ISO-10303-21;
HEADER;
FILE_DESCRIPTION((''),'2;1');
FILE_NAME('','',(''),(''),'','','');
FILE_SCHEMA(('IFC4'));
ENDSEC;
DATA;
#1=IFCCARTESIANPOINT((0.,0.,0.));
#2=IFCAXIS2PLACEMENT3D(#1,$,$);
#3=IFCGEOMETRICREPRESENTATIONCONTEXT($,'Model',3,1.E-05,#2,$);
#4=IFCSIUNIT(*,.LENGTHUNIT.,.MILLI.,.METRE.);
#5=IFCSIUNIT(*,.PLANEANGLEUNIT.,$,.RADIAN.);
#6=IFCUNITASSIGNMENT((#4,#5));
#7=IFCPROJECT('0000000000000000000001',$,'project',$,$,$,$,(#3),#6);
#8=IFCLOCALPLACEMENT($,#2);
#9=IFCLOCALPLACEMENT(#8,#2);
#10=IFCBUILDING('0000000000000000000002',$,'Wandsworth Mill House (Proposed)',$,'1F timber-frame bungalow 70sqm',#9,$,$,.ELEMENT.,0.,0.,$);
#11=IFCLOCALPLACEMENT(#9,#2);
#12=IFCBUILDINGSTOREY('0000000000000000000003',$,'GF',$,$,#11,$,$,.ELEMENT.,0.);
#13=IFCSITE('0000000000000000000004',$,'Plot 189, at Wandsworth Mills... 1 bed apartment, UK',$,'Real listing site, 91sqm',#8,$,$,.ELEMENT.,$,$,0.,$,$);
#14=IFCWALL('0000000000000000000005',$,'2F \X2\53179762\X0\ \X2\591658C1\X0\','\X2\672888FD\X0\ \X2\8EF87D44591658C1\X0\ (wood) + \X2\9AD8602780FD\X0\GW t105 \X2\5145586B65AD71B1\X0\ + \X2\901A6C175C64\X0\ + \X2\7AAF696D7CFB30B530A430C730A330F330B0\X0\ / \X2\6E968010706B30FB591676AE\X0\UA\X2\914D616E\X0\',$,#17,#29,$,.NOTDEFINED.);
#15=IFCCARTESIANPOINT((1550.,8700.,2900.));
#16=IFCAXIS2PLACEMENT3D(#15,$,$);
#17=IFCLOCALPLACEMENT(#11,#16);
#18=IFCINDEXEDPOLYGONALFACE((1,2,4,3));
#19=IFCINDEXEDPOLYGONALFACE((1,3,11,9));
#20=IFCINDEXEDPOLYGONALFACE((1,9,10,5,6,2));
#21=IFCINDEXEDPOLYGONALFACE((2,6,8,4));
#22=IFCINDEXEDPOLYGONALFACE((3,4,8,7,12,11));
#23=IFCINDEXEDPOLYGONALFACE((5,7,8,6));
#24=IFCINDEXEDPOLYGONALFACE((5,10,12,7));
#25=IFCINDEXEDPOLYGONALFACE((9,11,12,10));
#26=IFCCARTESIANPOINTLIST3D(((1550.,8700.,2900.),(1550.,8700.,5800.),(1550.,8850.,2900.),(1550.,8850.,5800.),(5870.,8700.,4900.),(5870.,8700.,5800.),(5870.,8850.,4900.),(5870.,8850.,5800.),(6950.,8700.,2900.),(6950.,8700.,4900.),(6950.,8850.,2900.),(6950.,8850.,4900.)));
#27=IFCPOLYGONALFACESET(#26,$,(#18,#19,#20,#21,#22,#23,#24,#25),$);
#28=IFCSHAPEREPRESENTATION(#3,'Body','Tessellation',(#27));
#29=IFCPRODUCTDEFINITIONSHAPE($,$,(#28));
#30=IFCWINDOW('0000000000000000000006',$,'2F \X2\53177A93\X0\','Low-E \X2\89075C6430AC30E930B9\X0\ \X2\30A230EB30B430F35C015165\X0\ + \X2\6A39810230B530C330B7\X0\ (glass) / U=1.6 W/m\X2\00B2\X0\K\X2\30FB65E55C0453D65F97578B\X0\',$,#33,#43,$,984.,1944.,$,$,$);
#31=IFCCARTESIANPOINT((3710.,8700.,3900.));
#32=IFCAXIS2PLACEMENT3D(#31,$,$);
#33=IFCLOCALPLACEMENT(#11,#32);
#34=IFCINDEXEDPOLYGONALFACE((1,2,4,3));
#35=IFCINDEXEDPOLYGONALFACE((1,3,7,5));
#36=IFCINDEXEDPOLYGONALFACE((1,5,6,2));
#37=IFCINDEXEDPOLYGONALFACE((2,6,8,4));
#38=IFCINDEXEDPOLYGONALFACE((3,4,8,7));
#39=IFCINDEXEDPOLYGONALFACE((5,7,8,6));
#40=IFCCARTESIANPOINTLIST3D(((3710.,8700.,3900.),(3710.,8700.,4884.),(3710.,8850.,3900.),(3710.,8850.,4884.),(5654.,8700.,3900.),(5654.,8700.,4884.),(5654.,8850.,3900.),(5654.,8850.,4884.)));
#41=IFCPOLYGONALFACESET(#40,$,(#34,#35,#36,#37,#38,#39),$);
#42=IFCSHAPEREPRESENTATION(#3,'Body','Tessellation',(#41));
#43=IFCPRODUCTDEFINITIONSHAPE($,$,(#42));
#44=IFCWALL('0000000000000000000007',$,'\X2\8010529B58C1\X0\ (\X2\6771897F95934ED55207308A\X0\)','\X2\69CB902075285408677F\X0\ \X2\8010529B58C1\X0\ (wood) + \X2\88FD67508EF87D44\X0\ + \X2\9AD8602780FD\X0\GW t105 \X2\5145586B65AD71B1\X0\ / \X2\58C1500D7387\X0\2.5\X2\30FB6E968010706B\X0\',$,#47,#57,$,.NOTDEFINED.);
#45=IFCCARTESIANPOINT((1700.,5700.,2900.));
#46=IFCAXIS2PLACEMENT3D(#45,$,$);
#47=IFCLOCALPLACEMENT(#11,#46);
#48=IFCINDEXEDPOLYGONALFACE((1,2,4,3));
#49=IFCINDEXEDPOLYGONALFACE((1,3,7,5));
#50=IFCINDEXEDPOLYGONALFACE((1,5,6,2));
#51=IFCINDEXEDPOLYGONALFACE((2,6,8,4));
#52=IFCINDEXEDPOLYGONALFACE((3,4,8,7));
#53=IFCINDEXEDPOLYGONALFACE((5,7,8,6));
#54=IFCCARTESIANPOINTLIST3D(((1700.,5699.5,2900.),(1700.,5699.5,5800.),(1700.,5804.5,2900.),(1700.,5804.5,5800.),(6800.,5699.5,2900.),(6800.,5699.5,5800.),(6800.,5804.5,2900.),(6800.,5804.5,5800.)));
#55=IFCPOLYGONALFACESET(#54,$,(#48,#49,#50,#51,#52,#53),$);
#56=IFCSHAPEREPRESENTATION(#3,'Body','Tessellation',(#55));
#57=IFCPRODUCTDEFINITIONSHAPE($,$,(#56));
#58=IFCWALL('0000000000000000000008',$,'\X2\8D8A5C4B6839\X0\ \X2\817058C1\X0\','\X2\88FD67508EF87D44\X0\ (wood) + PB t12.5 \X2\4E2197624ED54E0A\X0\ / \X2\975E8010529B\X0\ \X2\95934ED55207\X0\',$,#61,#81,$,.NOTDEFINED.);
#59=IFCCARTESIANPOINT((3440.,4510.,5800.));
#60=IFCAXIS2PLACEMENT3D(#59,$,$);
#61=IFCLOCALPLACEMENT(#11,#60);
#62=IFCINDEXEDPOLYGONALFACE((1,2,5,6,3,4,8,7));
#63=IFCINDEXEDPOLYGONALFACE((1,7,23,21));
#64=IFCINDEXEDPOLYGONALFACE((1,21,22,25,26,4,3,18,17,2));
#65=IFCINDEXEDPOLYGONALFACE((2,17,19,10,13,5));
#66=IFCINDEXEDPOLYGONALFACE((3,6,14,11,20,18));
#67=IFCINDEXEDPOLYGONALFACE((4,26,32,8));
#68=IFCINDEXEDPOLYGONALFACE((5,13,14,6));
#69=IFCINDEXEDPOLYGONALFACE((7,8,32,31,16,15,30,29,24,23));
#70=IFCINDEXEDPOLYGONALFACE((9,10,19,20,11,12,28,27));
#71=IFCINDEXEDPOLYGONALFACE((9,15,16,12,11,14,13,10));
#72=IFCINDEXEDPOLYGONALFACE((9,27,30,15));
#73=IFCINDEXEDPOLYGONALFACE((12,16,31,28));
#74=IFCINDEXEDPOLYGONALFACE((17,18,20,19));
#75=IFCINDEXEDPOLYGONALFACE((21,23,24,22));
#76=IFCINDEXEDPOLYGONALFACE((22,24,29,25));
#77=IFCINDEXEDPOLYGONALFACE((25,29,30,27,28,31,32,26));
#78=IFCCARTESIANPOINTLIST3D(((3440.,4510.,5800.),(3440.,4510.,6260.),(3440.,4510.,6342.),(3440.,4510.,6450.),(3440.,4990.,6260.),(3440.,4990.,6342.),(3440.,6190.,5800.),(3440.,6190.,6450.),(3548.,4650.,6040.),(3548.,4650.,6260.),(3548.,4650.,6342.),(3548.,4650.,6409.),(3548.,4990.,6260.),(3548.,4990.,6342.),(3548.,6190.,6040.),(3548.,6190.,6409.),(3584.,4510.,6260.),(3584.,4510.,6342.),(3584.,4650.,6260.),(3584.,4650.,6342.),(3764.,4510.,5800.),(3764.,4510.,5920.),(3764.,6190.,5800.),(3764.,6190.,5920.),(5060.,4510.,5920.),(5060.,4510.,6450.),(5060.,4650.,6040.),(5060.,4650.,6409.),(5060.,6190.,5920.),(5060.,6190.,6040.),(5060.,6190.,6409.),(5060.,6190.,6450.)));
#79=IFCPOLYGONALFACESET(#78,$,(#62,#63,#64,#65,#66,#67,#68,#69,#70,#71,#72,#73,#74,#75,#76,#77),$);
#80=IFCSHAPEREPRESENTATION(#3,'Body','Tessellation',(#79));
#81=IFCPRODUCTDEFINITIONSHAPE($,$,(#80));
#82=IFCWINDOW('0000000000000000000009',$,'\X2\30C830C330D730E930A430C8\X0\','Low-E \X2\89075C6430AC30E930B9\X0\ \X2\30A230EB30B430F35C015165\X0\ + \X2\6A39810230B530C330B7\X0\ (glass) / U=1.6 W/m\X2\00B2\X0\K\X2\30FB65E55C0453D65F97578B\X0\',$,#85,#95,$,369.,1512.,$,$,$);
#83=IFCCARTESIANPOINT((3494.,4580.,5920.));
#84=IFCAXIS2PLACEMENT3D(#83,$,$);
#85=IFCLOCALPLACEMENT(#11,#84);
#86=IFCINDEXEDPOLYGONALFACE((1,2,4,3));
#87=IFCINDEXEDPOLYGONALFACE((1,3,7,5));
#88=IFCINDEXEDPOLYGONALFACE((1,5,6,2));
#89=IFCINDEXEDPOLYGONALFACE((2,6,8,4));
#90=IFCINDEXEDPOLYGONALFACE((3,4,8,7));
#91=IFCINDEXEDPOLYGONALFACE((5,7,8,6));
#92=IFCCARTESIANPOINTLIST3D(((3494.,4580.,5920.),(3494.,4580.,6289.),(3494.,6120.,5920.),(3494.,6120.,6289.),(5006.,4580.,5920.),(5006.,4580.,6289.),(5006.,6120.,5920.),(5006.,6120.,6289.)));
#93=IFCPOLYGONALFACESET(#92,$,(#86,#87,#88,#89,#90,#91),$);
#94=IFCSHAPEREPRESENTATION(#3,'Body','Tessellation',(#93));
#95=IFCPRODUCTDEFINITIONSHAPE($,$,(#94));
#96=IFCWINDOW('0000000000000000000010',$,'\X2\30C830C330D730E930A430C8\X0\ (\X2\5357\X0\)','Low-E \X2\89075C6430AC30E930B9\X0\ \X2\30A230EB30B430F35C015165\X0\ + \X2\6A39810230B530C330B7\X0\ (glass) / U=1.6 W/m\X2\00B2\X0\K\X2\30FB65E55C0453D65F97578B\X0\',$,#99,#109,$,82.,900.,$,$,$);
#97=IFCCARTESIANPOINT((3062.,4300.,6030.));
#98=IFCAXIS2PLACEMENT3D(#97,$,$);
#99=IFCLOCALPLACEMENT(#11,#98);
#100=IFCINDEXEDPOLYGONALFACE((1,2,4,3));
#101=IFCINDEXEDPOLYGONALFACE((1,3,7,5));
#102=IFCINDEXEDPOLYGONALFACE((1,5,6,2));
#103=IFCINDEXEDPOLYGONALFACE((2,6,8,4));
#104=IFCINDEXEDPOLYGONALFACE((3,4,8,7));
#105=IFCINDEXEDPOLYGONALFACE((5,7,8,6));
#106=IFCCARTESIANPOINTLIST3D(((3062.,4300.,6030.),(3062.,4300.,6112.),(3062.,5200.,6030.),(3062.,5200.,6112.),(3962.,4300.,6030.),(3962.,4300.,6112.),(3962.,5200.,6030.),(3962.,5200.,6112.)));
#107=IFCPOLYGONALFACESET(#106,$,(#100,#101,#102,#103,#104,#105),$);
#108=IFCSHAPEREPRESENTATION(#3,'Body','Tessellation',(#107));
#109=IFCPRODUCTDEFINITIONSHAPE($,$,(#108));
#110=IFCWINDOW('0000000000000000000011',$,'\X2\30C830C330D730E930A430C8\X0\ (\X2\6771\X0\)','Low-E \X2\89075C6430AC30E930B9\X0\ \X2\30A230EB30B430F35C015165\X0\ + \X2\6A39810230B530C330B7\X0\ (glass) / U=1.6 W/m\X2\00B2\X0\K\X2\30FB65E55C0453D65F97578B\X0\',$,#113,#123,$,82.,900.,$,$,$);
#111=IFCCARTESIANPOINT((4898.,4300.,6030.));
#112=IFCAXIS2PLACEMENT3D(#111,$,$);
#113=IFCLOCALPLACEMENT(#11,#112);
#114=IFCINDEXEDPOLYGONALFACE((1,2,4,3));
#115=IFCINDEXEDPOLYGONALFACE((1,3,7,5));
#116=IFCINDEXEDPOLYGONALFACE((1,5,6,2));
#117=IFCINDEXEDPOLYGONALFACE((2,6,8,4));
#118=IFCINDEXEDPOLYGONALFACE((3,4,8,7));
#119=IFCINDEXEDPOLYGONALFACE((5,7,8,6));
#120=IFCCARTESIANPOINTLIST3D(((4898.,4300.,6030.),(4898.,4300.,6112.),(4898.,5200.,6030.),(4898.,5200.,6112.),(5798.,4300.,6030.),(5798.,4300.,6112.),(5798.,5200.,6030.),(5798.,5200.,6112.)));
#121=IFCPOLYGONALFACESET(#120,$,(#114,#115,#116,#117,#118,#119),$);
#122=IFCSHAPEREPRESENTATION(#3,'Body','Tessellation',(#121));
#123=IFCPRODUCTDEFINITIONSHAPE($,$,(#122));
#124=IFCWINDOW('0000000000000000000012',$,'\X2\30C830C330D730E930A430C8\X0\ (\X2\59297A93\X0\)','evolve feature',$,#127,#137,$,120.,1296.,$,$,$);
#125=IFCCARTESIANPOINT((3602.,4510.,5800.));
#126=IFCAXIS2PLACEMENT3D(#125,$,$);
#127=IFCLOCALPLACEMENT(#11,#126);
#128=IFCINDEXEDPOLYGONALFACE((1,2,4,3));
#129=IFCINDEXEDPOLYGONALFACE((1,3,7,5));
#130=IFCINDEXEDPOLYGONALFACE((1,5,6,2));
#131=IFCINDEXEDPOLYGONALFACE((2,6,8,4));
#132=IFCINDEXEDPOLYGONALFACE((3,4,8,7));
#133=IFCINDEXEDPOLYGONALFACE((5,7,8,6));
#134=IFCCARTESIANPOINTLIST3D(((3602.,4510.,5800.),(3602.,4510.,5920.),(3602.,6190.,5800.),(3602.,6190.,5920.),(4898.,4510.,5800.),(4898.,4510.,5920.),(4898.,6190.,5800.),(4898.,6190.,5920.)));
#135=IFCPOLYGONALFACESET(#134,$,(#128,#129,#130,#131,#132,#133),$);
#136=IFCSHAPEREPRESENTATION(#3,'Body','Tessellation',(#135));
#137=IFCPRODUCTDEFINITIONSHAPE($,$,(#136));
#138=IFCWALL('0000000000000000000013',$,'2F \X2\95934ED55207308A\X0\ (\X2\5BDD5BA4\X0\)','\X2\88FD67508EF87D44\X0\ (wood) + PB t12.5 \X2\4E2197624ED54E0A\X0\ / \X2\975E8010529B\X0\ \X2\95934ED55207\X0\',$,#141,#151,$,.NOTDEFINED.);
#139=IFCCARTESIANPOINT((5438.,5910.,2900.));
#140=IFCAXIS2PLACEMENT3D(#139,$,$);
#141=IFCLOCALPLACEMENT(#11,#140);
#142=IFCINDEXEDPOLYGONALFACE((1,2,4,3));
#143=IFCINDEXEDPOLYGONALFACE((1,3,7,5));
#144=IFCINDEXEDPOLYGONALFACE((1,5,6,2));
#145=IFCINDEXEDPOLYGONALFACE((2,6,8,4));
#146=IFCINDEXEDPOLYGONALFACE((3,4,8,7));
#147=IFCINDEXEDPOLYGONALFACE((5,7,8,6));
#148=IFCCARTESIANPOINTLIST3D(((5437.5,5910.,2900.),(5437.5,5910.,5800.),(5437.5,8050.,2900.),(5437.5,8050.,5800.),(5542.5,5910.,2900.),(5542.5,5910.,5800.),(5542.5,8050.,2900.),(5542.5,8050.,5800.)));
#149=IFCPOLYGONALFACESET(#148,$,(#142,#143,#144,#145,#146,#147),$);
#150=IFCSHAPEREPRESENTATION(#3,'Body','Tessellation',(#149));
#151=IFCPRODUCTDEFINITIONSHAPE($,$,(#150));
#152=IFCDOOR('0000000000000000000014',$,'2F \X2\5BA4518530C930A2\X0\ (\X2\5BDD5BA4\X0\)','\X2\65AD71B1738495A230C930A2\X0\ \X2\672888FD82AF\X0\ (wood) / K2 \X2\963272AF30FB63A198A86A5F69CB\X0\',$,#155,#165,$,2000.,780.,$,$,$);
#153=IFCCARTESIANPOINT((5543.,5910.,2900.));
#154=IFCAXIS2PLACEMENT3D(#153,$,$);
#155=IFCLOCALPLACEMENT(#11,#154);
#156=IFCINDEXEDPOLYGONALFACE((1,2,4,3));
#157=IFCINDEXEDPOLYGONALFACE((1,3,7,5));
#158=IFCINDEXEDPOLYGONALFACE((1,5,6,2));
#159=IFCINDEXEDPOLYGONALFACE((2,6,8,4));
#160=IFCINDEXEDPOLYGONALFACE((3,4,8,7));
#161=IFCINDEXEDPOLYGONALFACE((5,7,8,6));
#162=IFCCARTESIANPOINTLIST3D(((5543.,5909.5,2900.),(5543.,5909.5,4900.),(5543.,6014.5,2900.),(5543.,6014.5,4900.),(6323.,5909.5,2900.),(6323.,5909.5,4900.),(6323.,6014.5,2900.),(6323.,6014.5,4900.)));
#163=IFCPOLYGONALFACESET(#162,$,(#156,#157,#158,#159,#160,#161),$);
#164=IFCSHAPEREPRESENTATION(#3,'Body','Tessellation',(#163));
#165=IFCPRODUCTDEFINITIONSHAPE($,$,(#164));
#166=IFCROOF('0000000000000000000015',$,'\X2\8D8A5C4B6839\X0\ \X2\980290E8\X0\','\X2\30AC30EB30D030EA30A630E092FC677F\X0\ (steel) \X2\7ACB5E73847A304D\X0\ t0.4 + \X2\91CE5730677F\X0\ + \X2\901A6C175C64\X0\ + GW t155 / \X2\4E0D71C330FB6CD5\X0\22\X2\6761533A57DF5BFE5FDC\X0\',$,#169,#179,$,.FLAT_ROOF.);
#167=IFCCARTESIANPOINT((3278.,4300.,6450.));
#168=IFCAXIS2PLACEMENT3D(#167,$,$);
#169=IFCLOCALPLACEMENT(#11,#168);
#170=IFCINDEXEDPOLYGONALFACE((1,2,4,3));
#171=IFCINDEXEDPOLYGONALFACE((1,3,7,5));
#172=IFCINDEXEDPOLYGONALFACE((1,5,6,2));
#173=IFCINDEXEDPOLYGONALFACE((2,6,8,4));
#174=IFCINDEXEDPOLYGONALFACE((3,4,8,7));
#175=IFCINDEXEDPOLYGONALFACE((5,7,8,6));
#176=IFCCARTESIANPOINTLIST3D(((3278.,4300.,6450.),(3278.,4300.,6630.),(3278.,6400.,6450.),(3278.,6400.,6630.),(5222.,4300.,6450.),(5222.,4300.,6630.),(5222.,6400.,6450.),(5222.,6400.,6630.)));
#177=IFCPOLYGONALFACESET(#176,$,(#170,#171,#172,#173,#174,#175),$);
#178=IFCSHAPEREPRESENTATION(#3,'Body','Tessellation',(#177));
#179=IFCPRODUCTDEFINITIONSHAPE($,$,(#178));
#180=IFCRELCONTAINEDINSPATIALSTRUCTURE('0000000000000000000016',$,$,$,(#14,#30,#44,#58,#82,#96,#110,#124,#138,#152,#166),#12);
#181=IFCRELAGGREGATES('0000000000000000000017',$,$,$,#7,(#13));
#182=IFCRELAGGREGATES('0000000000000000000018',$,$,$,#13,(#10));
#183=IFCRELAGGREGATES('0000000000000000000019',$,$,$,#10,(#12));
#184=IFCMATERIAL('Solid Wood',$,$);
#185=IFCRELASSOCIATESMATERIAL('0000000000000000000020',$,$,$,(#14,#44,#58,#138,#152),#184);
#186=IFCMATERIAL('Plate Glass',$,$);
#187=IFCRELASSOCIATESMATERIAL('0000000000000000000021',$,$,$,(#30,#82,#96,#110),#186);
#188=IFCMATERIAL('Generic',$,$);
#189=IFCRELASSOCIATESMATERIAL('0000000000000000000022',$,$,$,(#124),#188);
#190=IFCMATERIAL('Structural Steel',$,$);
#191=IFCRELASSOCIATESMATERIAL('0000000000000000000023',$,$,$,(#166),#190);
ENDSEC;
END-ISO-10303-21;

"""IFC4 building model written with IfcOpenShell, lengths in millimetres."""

from ifc_helpers import new_model, si_unit, frame, frame_2d, origin, place, context, project, spatial, rectangle, extrude, material, element, fill, save


model = new_model("IFC4")

# Units and contexts
model_context = context("Model", 3, precision=1e-05, world=origin())
ifc_project = project(units=[si_unit("LENGTHUNIT", "METRE", prefix="MILLI"), si_unit("PLANEANGLEUNIT", "RADIAN")], contexts=[model_context])

# Site, building, storey
site_placement = place(None, origin())
site = spatial("IfcSite", under=ifc_project, at=site_placement, Name="Plot 189, at Wandsworth Mills... 1 bed apartment, UK", ObjectType="Real listing site, 91sqm", CompositionType="ELEMENT", RefElevation=0.0)
building_placement = place(site_placement, origin())
building = spatial("IfcBuilding", under=site, at=building_placement, Name="Wandsworth Mill House (Proposed)", ObjectType="1F timber-frame bungalow 70sqm", CompositionType="ELEMENT", ElevationOfRefHeight=0.0, ElevationOfTerrain=0.0)
storey_placement = place(building_placement, origin())
storey = spatial("IfcBuildingStorey", under=building, at=storey_placement, Name="GF", CompositionType="ELEMENT", Elevation=0.0)

# Wall, opening, window
ifc_material_1 = material(Name="Solid Wood")
wall_1_placement = place(storey_placement, frame((1550.0, 8700.0, 2900.0)))
wall_1 = element("IfcWall", 1, at=wall_1_placement, inside=storey, material=ifc_material_1, Name="2F 北面 外壁", Description="木製 軸組外壁 (wood) + 高性能GW t105 充填断熱 + 通気層 + 窯業系サイディング / 準耐火・外皮UA配慮", PredefinedType="NOTDEFINED", context=model_context, shape_type="SweptSolid", body=[
    extrude(rectangle(XDim=5400.0, YDim=150.0, at=frame_2d((2700.0, 75.0))), frame((1550.0, 8700.0, 2900.0)), (0.0, 0.0, 1.0), 2900.0),
])
opening_1_placement = place(storey_placement, frame((3710.0, 8700.0, 3900.0)))
opening_1 = element("IfcOpeningElement", 2, at=opening_1_placement, cuts=wall_1, PredefinedType="NOTDEFINED", context=model_context, shape_type="SweptSolid", body=[
    extrude(rectangle(XDim=1944.0, YDim=150.0, at=frame_2d((972.0, 75.0))), frame((3710.0, 8700.0, 3900.0)), (0.0, 0.0, 1.0), 984.0),
])
ifc_material_2 = material(Name="Plate Glass")
window_1_placement = place(storey_placement, frame((3710.0, 8700.0, 3900.0)))
window_1 = element("IfcWindow", 3, at=window_1_placement, inside=storey, material=ifc_material_2, Name="2F 北窓", Description="Low-E 複層ガラス アルゴン封入 + 樹脂サッシ (glass) / U=1.6 W/m²K・日射取得型", OverallHeight=984.0, OverallWidth=1944.0, context=model_context, shape_type="SweptSolid", body=[
    extrude(rectangle(XDim=1944.0, YDim=150.0, at=frame_2d((972.0, 75.0))), frame((3710.0, 8700.0, 3900.0)), (0.0, 0.0, 1.0), 984.0),
])
fill(opening_1, window_1)

# Wall
wall_2_placement = place(storey_placement, frame((1700.0, 5700.0, 2900.0)))
element("IfcWall", 4, at=wall_2_placement, inside=storey, material=ifc_material_1, Name="耐力壁 (東西間仕切り)", Description="構造用合板 耐力壁 (wood) + 製材軸組 + 高性能GW t105 充填断熱 / 壁倍率2.5・準耐火", PredefinedType="NOTDEFINED", context=model_context, shape_type="SweptSolid", body=[
    extrude(rectangle(XDim=5100.0, YDim=105.0, at=frame_2d((2550.0, 52.0))), frame((1700.0, 5700.0, 2900.0)), (0.0, 0.0, 1.0), 2900.0),
])

# Wall, openings, windows
wall_3_placement = place(storey_placement, frame((3440.0, 4510.0, 5800.0)))
wall_3 = element("IfcWall", 5, at=wall_3_placement, inside=storey, material=ifc_material_1, Name="越屋根 腰壁", Description="製材軸組 (wood) + PB t12.5 両面仕上 / 非耐力 間仕切", PredefinedType="NOTDEFINED", context=model_context, shape_type="SweptSolid", body=[
    extrude(rectangle(XDim=1620.0, YDim=1680.0, at=frame_2d((810.0, 840.0))), frame((3440.0, 4510.0, 5800.0)), (0.0, 0.0, 1.0), 650.0),
])
opening_2_placement = place(storey_placement, frame((3494.0, 4580.0, 5920.0)))
opening_2 = element("IfcOpeningElement", 6, at=opening_2_placement, cuts=wall_3, PredefinedType="NOTDEFINED", context=model_context, shape_type="SweptSolid", body=[
    extrude(rectangle(XDim=1512.0, YDim=1540.0, at=frame_2d((756.0, 770.0))), frame((3494.0, 4580.0, 5920.0)), (0.0, 0.0, 1.0), 369.0),
])
opening_3_placement = place(storey_placement, frame((3062.0, 4300.0, 6030.0)))
opening_3 = element("IfcOpeningElement", 7, at=opening_3_placement, cuts=wall_3, PredefinedType="NOTDEFINED", context=model_context, shape_type="SweptSolid", body=[
    extrude(rectangle(XDim=900.0, YDim=900.0, at=frame_2d((450.0, 450.0))), frame((3062.0, 4300.0, 6030.0)), (0.0, 0.0, 1.0), 82.0),
])
opening_4_placement = place(storey_placement, frame((4898.0, 4300.0, 6030.0)))
opening_4 = element("IfcOpeningElement", 8, at=opening_4_placement, cuts=wall_3, PredefinedType="NOTDEFINED", context=model_context, shape_type="SweptSolid", body=[
    extrude(rectangle(XDim=900.0, YDim=900.0, at=frame_2d((450.0, 450.0))), frame((4898.0, 4300.0, 6030.0)), (0.0, 0.0, 1.0), 82.0),
])
opening_5_placement = place(storey_placement, frame((3602.0, 4510.0, 5800.0)))
opening_5 = element("IfcOpeningElement", 9, at=opening_5_placement, cuts=wall_3, PredefinedType="NOTDEFINED", context=model_context, shape_type="SweptSolid", body=[
    extrude(rectangle(XDim=1296.0, YDim=1680.0, at=frame_2d((648.0, 840.0))), frame((3602.0, 4510.0, 5800.0)), (0.0, 0.0, 1.0), 120.0),
])
window_2_placement = place(storey_placement, frame((3494.0, 4580.0, 5920.0)))
window_2 = element("IfcWindow", 10, at=window_2_placement, inside=storey, material=ifc_material_2, Name="トップライト", Description="Low-E 複層ガラス アルゴン封入 + 樹脂サッシ (glass) / U=1.6 W/m²K・日射取得型", OverallHeight=369.0, OverallWidth=1512.0, context=model_context, shape_type="SweptSolid", body=[
    extrude(rectangle(XDim=1512.0, YDim=1540.0, at=frame_2d((756.0, 770.0))), frame((3494.0, 4580.0, 5920.0)), (0.0, 0.0, 1.0), 369.0),
])
fill(opening_2, window_2)
window_3_placement = place(storey_placement, frame((3062.0, 4300.0, 6030.0)))
window_3 = element("IfcWindow", 11, at=window_3_placement, inside=storey, material=ifc_material_2, Name="トップライト (南)", Description="Low-E 複層ガラス アルゴン封入 + 樹脂サッシ (glass) / U=1.6 W/m²K・日射取得型", OverallHeight=82.0, OverallWidth=900.0, context=model_context, shape_type="SweptSolid", body=[
    extrude(rectangle(XDim=900.0, YDim=900.0, at=frame_2d((450.0, 450.0))), frame((3062.0, 4300.0, 6030.0)), (0.0, 0.0, 1.0), 82.0),
])
fill(opening_3, window_3)
window_4_placement = place(storey_placement, frame((4898.0, 4300.0, 6030.0)))
window_4 = element("IfcWindow", 12, at=window_4_placement, inside=storey, material=ifc_material_2, Name="トップライト (東)", Description="Low-E 複層ガラス アルゴン封入 + 樹脂サッシ (glass) / U=1.6 W/m²K・日射取得型", OverallHeight=82.0, OverallWidth=900.0, context=model_context, shape_type="SweptSolid", body=[
    extrude(rectangle(XDim=900.0, YDim=900.0, at=frame_2d((450.0, 450.0))), frame((4898.0, 4300.0, 6030.0)), (0.0, 0.0, 1.0), 82.0),
])
fill(opening_4, window_4)
ifc_material_3 = material(Name="Generic")
window_5_placement = place(storey_placement, frame((3602.0, 4510.0, 5800.0)))
window_5 = element("IfcWindow", 13, at=window_5_placement, inside=storey, material=ifc_material_3, Name="トップライト (天窓)", Description="evolve feature", OverallHeight=120.0, OverallWidth=1296.0, context=model_context, shape_type="SweptSolid", body=[
    extrude(rectangle(XDim=1296.0, YDim=1680.0, at=frame_2d((648.0, 840.0))), frame((3602.0, 4510.0, 5800.0)), (0.0, 0.0, 1.0), 120.0),
])
fill(opening_5, window_5)

# Wall
wall_4_placement = place(storey_placement, frame((5438.0, 5910.0, 2900.0)))
element("IfcWall", 14, at=wall_4_placement, inside=storey, material=ifc_material_1, Name="2F 間仕切り (寝室)", Description="製材軸組 (wood) + PB t12.5 両面仕上 / 非耐力 間仕切", PredefinedType="NOTDEFINED", context=model_context, shape_type="SweptSolid", body=[
    extrude(rectangle(XDim=105.0, YDim=2140.0, at=frame_2d((52.0, 1070.0))), frame((5438.0, 5910.0, 2900.0)), (0.0, 0.0, 1.0), 2900.0),
])

# Door
door_placement = place(storey_placement, frame((5543.0, 5910.0, 2900.0)))
element("IfcDoor", 15, at=door_placement, inside=storey, material=ifc_material_1, Name="2F 室内ドア (寝室)", Description="断熱玄関ドア 木製芯 (wood) / K2 防犯・採風機構", OverallHeight=2000.0, OverallWidth=780.0, context=model_context, shape_type="SweptSolid", body=[
    extrude(rectangle(XDim=780.0, YDim=105.0, at=frame_2d((390.0, 52.0))), frame((5543.0, 5910.0, 2900.0)), (0.0, 0.0, 1.0), 2000.0),
])

# Roof
ifc_material_4 = material(Name="Structural Steel")
roof_placement = place(storey_placement, frame((3278.0, 4300.0, 6450.0)))
element("IfcRoof", 16, at=roof_placement, inside=storey, material=ifc_material_4, Name="越屋根 頂部", Description="ガルバリウム鋼板 (steel) 立平葺き t0.4 + 野地板 + 通気層 + GW t155 / 不燃・法22条区域対応", PredefinedType="FLAT_ROOF", context=model_context, shape_type="SweptSolid", body=[
    extrude(rectangle(XDim=1944.0, YDim=2100.0, at=frame_2d((972.0, 1050.0))), frame((3278.0, 4300.0, 6450.0)), (0.0, 0.0, 1.0), 180.0),
])

save(model, "model.ifc")
